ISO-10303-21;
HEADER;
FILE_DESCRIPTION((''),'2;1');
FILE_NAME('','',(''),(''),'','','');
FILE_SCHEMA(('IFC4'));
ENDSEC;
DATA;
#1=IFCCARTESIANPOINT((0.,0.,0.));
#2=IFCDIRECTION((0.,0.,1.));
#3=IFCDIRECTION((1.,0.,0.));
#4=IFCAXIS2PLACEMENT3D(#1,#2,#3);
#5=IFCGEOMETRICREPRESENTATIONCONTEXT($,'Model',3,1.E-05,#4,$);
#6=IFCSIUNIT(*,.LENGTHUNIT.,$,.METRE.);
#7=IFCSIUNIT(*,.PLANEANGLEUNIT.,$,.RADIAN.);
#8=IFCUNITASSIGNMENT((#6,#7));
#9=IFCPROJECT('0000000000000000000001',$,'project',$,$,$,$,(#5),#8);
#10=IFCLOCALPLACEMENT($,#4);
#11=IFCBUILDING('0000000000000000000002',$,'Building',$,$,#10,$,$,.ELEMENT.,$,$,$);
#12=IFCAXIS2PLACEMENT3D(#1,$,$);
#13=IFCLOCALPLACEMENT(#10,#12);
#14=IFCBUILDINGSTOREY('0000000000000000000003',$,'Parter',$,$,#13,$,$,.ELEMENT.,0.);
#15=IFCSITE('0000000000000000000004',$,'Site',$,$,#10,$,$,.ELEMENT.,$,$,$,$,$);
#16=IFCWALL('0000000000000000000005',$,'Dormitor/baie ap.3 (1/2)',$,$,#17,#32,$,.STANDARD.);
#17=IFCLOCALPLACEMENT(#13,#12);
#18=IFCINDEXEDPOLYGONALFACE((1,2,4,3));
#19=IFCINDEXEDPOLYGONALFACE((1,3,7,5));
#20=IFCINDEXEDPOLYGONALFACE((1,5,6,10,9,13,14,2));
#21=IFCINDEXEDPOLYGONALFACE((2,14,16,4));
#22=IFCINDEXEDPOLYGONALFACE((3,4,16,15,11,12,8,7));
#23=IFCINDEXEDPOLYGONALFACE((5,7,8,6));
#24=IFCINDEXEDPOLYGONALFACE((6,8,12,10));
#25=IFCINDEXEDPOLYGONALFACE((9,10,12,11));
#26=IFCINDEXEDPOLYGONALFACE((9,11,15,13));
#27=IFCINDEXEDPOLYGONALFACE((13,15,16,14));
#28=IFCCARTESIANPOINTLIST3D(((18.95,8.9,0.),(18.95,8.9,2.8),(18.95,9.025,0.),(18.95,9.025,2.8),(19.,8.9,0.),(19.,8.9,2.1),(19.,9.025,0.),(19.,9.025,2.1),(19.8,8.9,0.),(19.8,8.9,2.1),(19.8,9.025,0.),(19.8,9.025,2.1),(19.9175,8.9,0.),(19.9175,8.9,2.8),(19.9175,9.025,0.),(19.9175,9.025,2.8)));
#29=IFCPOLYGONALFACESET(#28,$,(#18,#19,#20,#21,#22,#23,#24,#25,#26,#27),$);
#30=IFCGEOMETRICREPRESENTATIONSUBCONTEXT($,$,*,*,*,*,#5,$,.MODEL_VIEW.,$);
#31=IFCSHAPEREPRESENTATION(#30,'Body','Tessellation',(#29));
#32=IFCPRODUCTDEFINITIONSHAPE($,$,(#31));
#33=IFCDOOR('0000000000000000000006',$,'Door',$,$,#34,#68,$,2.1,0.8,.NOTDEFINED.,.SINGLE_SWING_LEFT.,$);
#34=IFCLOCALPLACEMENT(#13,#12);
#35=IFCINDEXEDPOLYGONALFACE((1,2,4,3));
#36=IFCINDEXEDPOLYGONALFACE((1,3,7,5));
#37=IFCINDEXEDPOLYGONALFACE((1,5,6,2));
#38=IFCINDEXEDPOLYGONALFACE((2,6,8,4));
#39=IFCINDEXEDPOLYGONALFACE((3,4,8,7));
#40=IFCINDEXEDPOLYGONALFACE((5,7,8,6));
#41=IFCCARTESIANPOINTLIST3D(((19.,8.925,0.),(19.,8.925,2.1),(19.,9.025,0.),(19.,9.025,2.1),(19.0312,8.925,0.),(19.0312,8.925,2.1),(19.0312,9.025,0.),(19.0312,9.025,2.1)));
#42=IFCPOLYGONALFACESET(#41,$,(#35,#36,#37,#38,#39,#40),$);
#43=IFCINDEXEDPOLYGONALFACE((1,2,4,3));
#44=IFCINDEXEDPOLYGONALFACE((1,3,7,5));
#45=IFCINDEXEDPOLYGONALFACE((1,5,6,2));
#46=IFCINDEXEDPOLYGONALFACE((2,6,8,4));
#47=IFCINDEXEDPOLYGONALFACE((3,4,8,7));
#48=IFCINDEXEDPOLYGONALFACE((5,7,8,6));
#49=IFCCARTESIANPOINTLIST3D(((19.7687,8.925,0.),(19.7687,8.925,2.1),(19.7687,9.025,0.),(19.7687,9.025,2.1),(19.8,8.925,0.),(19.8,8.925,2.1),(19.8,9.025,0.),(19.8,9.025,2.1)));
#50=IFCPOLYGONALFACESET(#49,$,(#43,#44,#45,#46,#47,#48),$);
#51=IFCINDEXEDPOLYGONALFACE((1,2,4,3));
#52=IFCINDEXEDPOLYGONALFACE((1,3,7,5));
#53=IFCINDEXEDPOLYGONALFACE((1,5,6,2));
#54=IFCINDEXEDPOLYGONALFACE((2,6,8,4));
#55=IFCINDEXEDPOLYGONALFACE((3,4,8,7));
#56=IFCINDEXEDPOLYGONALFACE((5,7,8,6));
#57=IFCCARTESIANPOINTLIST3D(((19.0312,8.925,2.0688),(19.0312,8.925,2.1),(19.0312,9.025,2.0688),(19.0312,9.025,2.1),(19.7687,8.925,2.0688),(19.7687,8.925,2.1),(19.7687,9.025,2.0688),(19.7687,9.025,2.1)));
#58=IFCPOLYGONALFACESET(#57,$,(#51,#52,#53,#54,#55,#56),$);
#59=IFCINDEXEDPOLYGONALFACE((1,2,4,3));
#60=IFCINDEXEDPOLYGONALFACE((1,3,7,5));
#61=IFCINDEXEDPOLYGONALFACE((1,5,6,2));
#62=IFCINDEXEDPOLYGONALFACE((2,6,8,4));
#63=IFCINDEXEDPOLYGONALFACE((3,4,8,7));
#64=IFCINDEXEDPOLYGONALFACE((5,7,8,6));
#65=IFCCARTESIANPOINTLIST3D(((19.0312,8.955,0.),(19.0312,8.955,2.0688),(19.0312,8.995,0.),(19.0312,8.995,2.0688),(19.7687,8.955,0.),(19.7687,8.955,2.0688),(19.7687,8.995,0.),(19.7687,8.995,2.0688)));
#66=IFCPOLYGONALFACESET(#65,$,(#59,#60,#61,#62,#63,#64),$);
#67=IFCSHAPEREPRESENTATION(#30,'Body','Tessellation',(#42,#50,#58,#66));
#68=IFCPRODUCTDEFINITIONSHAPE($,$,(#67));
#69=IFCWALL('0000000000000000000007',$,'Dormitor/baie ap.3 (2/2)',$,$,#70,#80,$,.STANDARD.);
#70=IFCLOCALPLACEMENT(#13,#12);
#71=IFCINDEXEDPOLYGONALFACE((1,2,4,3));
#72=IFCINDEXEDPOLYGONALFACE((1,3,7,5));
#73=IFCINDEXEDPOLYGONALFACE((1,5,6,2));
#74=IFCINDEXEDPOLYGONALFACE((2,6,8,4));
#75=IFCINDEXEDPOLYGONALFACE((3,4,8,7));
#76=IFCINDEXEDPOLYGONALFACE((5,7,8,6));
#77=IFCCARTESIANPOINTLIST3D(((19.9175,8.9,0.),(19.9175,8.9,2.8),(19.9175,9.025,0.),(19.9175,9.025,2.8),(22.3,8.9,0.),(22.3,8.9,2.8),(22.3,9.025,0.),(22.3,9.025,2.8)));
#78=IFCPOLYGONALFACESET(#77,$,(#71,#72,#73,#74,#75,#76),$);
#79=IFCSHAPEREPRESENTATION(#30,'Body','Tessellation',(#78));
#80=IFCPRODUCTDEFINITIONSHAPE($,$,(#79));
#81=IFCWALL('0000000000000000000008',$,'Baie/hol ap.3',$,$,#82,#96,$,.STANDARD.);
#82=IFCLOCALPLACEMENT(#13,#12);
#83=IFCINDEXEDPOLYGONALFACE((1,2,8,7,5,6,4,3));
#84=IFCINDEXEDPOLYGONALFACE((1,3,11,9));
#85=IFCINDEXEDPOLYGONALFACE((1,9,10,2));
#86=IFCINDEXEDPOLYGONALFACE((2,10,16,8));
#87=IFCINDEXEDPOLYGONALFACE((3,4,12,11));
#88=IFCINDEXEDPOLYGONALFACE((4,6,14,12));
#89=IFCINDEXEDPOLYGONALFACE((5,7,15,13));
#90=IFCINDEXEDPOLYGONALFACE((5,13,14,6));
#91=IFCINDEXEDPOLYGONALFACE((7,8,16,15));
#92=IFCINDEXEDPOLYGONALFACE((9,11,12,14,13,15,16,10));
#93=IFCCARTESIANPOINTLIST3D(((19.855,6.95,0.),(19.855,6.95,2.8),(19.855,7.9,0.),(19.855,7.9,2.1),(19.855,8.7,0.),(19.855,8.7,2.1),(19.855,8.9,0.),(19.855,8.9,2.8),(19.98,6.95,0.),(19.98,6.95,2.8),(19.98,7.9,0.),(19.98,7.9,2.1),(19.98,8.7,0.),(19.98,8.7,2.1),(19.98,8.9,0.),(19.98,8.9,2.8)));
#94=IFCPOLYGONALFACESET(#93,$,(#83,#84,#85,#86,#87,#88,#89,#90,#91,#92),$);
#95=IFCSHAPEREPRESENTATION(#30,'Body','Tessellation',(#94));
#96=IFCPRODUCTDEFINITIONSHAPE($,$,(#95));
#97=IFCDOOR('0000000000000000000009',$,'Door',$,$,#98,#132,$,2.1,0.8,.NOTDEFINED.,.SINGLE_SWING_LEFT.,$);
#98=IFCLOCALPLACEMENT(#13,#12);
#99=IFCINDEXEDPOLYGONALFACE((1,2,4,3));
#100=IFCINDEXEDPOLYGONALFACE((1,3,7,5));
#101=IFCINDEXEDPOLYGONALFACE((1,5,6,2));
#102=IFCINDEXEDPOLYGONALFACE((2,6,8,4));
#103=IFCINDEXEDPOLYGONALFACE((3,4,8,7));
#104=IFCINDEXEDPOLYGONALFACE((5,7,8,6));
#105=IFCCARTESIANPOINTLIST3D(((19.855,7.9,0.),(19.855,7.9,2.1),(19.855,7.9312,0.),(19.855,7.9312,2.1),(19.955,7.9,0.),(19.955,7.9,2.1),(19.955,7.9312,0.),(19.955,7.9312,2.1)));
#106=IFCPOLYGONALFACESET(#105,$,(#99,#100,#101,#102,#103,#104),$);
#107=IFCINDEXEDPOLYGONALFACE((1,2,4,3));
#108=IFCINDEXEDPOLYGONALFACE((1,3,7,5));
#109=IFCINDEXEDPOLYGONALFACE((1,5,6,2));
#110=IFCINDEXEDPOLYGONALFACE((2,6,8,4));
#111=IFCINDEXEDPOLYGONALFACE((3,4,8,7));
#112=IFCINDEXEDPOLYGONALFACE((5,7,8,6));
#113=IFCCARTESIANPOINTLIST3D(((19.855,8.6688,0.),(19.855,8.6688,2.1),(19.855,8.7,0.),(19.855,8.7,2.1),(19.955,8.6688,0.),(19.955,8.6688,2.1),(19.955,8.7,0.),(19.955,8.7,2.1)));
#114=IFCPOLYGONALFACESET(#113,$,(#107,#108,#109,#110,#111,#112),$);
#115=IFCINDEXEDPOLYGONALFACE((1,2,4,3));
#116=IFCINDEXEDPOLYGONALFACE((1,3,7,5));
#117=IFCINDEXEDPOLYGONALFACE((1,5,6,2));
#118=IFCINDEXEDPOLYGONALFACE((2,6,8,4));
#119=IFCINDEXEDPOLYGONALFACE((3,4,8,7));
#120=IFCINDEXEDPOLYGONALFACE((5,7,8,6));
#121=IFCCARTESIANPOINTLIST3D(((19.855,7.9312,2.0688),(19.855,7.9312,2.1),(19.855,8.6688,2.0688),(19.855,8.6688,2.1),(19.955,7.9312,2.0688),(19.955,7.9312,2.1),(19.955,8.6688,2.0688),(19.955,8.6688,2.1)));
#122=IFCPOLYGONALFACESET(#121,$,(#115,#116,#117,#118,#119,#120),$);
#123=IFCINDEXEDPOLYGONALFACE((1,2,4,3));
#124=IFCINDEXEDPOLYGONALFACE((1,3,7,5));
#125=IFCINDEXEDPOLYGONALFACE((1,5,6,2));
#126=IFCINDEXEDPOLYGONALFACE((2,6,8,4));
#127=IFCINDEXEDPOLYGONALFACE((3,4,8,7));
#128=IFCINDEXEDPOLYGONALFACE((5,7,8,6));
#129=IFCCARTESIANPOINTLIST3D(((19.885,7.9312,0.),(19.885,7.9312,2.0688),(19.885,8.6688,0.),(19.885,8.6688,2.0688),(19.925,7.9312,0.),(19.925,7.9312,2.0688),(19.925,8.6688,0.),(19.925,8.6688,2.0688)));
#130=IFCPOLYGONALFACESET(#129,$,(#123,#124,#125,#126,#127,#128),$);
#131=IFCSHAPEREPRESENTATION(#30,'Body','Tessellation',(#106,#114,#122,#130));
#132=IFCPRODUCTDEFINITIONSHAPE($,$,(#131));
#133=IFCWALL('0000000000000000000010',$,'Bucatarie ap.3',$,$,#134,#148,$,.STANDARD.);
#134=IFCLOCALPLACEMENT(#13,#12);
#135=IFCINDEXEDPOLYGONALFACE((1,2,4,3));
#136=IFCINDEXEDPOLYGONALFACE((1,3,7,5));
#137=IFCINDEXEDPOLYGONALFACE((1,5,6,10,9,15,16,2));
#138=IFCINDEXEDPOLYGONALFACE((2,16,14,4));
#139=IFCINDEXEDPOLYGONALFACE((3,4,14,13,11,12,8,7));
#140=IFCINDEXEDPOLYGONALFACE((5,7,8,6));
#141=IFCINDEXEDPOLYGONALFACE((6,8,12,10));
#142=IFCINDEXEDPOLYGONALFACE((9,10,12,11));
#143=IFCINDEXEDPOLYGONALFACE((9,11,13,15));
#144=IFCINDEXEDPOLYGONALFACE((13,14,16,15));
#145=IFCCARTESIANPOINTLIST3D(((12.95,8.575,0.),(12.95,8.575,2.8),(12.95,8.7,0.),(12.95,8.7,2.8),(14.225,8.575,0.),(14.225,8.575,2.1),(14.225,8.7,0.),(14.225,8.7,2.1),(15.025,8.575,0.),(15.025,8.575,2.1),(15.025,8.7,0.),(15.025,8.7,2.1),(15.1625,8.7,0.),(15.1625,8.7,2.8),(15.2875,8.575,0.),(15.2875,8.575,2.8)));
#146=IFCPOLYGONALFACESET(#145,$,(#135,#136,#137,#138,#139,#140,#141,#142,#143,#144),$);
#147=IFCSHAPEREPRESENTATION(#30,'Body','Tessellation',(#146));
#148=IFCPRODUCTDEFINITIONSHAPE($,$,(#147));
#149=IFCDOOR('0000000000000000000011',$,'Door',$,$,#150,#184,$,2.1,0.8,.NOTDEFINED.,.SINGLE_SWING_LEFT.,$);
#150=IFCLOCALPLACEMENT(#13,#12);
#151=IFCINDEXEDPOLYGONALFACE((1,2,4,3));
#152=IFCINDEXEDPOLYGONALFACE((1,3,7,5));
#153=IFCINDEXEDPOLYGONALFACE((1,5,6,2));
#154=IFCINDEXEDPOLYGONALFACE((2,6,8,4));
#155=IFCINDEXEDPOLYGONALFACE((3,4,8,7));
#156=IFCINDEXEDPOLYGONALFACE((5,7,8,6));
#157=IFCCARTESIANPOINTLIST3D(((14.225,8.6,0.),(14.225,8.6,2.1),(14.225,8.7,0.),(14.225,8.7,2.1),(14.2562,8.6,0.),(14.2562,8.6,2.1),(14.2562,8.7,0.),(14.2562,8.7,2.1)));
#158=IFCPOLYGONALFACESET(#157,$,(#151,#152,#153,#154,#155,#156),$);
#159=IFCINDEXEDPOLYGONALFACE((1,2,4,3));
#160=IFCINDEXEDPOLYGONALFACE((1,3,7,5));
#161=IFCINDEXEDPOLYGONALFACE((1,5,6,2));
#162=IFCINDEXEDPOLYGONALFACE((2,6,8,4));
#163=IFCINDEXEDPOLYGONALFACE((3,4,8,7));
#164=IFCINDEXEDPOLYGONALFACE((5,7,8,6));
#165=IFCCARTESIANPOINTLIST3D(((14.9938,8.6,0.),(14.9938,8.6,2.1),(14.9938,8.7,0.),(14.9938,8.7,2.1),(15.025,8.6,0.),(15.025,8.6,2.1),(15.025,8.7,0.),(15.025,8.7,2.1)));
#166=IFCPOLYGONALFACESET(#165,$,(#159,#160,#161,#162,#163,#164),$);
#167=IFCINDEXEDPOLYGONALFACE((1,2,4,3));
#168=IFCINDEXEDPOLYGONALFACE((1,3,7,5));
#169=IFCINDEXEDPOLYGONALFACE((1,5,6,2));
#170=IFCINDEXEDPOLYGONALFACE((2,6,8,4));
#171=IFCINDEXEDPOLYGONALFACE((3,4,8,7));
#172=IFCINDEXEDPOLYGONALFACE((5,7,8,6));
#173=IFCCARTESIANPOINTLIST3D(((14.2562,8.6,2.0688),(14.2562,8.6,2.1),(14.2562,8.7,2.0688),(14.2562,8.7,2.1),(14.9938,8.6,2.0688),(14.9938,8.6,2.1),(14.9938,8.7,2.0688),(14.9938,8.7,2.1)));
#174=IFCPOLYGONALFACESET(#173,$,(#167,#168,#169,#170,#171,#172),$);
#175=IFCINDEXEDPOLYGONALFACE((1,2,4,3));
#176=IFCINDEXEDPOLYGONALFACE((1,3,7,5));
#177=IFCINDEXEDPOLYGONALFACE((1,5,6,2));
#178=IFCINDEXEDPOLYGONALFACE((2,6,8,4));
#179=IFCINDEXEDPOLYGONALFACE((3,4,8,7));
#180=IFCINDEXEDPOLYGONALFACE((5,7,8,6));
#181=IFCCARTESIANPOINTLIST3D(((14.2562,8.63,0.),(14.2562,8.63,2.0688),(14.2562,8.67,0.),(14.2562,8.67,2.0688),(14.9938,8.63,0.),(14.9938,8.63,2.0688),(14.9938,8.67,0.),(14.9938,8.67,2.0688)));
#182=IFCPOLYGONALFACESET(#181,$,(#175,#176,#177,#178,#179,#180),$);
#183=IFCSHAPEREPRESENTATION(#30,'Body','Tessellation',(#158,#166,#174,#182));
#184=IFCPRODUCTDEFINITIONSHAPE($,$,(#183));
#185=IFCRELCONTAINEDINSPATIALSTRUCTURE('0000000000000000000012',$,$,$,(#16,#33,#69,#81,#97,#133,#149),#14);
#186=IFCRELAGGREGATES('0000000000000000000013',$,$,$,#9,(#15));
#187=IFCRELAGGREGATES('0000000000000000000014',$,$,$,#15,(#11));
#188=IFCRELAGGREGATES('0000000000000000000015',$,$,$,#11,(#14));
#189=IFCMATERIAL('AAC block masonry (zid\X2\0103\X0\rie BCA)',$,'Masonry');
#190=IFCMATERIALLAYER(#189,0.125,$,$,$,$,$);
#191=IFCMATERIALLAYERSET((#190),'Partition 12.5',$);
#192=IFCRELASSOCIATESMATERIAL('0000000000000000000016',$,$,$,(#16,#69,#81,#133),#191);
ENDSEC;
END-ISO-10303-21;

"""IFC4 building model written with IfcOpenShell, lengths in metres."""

from ifc_helpers import new_model, si_unit, frame, frame_2d, origin, origin_with_axes, origin_2d, place, context, subcontext, project, spatial, rectangle, extrude, clip, halfspace, material, layer, layer_set, layer_usage, element, fill, save


model = new_model("IFC4")

# Units and contexts
model_context = context("Model", 3, precision=1e-05, world=origin_with_axes())
sub_context = subcontext(model_context, None, None, "MODEL_VIEW")
ifc_project = project(units=[si_unit("LENGTHUNIT", "METRE"), si_unit("PLANEANGLEUNIT", "RADIAN")], contexts=[model_context])

# Site, building, storey
placement = place(None, origin_with_axes())
site = spatial("IfcSite", under=ifc_project, at=placement, Name="Site", CompositionType="ELEMENT")
building = spatial("IfcBuilding", under=site, at=placement, Name="Building", CompositionType="ELEMENT")
storey_placement = place(placement, origin())
storey = spatial("IfcBuildingStorey", under=building, at=storey_placement, Name="Parter", CompositionType="ELEMENT", Elevation=0.0)

# Wall, opening, door
ifc_material_1 = material(Name="AAC block masonry (zidărie BCA)", Category="Masonry")
ifc_layer_1 = layer(ifc_material_1, 0.125)
ifc_layer_set_1 = layer_set([ifc_layer_1], Name="Partition 12.5")
ifc_layer_usage_1 = layer_usage(ifc_layer_set_1, "AXIS2", "POSITIVE", -0.0625)
wall_1_placement = place(storey_placement, frame((18.95, 8.9625, 0.0), x_axis=(1.0, 0.0, 0.0)))
wall_1 = element("IfcWall", 1, at=wall_1_placement, inside=storey, material=ifc_layer_usage_1, Name="Dormitor/baie ap.3 (1/2)", PredefinedType="STANDARD", context=sub_context, shape_type="SweptSolid", body=[
    extrude(rectangle(XDim=0.9675, YDim=0.125, at=frame_2d((0.4838, 0.0))), origin(), (0.0, 0.0, 1.0), 2.8),
])
opening_1_placement = place(wall_1_placement, frame((0.45, 0.1125, 0.0), z_axis=(0.0, -1.0, 0.0), x_axis=(1.0, 0.0, 0.0)))
opening_1 = element("IfcOpeningElement", 2, at=opening_1_placement, cuts=wall_1, PredefinedType="OPENING", context=sub_context, shape_type="SweptSolid", body=[
    extrude(rectangle(XDim=0.8, YDim=2.1, at=frame_2d((0.0, 1.05))), origin(), (0.0, 0.0, 1.0), 0.225),
])
door_1_placement = place(wall_1_placement, frame((0.45, 0.0625, 0.0), z_axis=(0.0, -1.0, 0.0), x_axis=(1.0, 0.0, 0.0)))
door_1 = element("IfcDoor", 3, at=door_1_placement, inside=storey, Name="Door", OperationType="SINGLE_SWING_LEFT", OverallHeight=2.1, OverallWidth=0.8, PredefinedType="NOTDEFINED", context=sub_context, shape_type="SweptSolid", body=[
    extrude(rectangle(XDim=0.0312, YDim=2.1, at=origin_2d()), frame((-0.3844, 1.05, 0.0)), (0.0, 0.0, 1.0), 0.1),
    extrude(rectangle(XDim=0.0312, YDim=2.1, at=origin_2d()), frame((0.3844, 1.05, 0.0)), (0.0, 0.0, 1.0), 0.1),
    extrude(rectangle(XDim=0.7375, YDim=0.0312, at=origin_2d()), frame((0.0, 2.0844, 0.0)), (0.0, 0.0, 1.0), 0.1),
    extrude(rectangle(XDim=0.7375, YDim=2.0688, at=origin_2d()), frame((0.0, 1.0344, 0.03)), (0.0, 0.0, 1.0), 0.04),
])
fill(opening_1, door_1)

# Wall
wall_2_placement = place(storey_placement, frame((19.9175, 8.9625, 0.0), x_axis=(1.0, 0.0, 0.0)))
element("IfcWall", 4, at=wall_2_placement, inside=storey, material=ifc_layer_usage_1, Name="Dormitor/baie ap.3 (2/2)", PredefinedType="STANDARD", context=sub_context, shape_type="SweptSolid", body=[
    extrude(rectangle(XDim=2.3825, YDim=0.125, at=frame_2d((1.1913, 0.0))), origin(), (0.0, 0.0, 1.0), 2.8),
])

# Walls, openings, doors
wall_3_placement = place(storey_placement, frame((19.9175, 6.95, 0.0), x_axis=(0.0, 1.0, 0.0)))
wall_3 = element("IfcWall", 5, at=wall_3_placement, inside=storey, material=ifc_layer_usage_1, Name="Baie/hol ap.3", PredefinedType="STANDARD", context=sub_context, shape_type="SweptSolid", body=[
    extrude(rectangle(XDim=1.95, YDim=0.125, at=frame_2d((0.975, 0.0))), origin(), (0.0, 0.0, 1.0), 2.8),
])
opening_2_placement = place(wall_3_placement, frame((1.35, 0.1125, 0.0), z_axis=(0.0, -1.0, 0.0), x_axis=(1.0, 0.0, 0.0)))
opening_2 = element("IfcOpeningElement", 6, at=opening_2_placement, cuts=wall_3, PredefinedType="OPENING", context=sub_context, shape_type="SweptSolid", body=[
    extrude(rectangle(XDim=0.8, YDim=2.1, at=frame_2d((0.0, 1.05))), origin(), (0.0, 0.0, 1.0), 0.225),
])
door_2_placement = place(wall_3_placement, frame((1.35, 0.0625, 0.0), z_axis=(0.0, -1.0, 0.0), x_axis=(1.0, 0.0, 0.0)))
door_2 = element("IfcDoor", 7, at=door_2_placement, inside=storey, Name="Door", OperationType="SINGLE_SWING_LEFT", OverallHeight=2.1, OverallWidth=0.8, PredefinedType="NOTDEFINED", context=sub_context, shape_type="SweptSolid", body=[
    extrude(rectangle(XDim=0.0312, YDim=2.1, at=origin_2d()), frame((-0.3844, 1.05, 0.0)), (0.0, 0.0, 1.0), 0.1),
    extrude(rectangle(XDim=0.0312, YDim=2.1, at=origin_2d()), frame((0.3844, 1.05, 0.0)), (0.0, 0.0, 1.0), 0.1),
    extrude(rectangle(XDim=0.7375, YDim=0.0312, at=origin_2d()), frame((0.0, 2.0844, 0.0)), (0.0, 0.0, 1.0), 0.1),
    extrude(rectangle(XDim=0.7375, YDim=2.0688, at=origin_2d()), frame((0.0, 1.0344, 0.03)), (0.0, 0.0, 1.0), 0.04),
])
fill(opening_2, door_2)
wall_4_placement = place(storey_placement, frame((12.95, 8.6375, 0.0), x_axis=(1.0, 0.0, 0.0)))
wall_4 = element("IfcWall", 8, at=wall_4_placement, inside=storey, material=ifc_layer_usage_1, Name="Bucatarie ap.3", PredefinedType="STANDARD", context=sub_context, shape_type="CSG", body=[
    clip(extrude(rectangle(XDim=2.3375, YDim=0.125, at=frame_2d((1.1687, 0.0))), origin(), (0.0, 0.0, 1.0), 2.8), halfspace(frame((2.275, 0.0, 0.0), z_axis=(0.707107, 0.707107, 0.0)), False)),
])
opening_3_placement = place(wall_4_placement, frame((1.675, 0.1125, 0.0), z_axis=(0.0, -1.0, 0.0), x_axis=(1.0, 0.0, 0.0)))
opening_3 = element("IfcOpeningElement", 9, at=opening_3_placement, cuts=wall_4, PredefinedType="OPENING", context=sub_context, shape_type="SweptSolid", body=[
    extrude(rectangle(XDim=0.8, YDim=2.1, at=frame_2d((0.0, 1.05))), origin(), (0.0, 0.0, 1.0), 0.225),
])
door_3_placement = place(wall_4_placement, frame((1.675, 0.0625, 0.0), z_axis=(0.0, -1.0, 0.0), x_axis=(1.0, 0.0, 0.0)))
door_3 = element("IfcDoor", 10, at=door_3_placement, inside=storey, Name="Door", OperationType="SINGLE_SWING_LEFT", OverallHeight=2.1, OverallWidth=0.8, PredefinedType="NOTDEFINED", context=sub_context, shape_type="SweptSolid", body=[
    extrude(rectangle(XDim=0.0312, YDim=2.1, at=origin_2d()), frame((-0.3844, 1.05, 0.0)), (0.0, 0.0, 1.0), 0.1),
    extrude(rectangle(XDim=0.0312, YDim=2.1, at=origin_2d()), frame((0.3844, 1.05, 0.0)), (0.0, 0.0, 1.0), 0.1),
    extrude(rectangle(XDim=0.7375, YDim=0.0312, at=origin_2d()), frame((0.0, 2.0844, 0.0)), (0.0, 0.0, 1.0), 0.1),
    extrude(rectangle(XDim=0.7375, YDim=2.0688, at=origin_2d()), frame((0.0, 1.0344, 0.03)), (0.0, 0.0, 1.0), 0.04),
])
fill(opening_3, door_3)

save(model, "model.ifc")
